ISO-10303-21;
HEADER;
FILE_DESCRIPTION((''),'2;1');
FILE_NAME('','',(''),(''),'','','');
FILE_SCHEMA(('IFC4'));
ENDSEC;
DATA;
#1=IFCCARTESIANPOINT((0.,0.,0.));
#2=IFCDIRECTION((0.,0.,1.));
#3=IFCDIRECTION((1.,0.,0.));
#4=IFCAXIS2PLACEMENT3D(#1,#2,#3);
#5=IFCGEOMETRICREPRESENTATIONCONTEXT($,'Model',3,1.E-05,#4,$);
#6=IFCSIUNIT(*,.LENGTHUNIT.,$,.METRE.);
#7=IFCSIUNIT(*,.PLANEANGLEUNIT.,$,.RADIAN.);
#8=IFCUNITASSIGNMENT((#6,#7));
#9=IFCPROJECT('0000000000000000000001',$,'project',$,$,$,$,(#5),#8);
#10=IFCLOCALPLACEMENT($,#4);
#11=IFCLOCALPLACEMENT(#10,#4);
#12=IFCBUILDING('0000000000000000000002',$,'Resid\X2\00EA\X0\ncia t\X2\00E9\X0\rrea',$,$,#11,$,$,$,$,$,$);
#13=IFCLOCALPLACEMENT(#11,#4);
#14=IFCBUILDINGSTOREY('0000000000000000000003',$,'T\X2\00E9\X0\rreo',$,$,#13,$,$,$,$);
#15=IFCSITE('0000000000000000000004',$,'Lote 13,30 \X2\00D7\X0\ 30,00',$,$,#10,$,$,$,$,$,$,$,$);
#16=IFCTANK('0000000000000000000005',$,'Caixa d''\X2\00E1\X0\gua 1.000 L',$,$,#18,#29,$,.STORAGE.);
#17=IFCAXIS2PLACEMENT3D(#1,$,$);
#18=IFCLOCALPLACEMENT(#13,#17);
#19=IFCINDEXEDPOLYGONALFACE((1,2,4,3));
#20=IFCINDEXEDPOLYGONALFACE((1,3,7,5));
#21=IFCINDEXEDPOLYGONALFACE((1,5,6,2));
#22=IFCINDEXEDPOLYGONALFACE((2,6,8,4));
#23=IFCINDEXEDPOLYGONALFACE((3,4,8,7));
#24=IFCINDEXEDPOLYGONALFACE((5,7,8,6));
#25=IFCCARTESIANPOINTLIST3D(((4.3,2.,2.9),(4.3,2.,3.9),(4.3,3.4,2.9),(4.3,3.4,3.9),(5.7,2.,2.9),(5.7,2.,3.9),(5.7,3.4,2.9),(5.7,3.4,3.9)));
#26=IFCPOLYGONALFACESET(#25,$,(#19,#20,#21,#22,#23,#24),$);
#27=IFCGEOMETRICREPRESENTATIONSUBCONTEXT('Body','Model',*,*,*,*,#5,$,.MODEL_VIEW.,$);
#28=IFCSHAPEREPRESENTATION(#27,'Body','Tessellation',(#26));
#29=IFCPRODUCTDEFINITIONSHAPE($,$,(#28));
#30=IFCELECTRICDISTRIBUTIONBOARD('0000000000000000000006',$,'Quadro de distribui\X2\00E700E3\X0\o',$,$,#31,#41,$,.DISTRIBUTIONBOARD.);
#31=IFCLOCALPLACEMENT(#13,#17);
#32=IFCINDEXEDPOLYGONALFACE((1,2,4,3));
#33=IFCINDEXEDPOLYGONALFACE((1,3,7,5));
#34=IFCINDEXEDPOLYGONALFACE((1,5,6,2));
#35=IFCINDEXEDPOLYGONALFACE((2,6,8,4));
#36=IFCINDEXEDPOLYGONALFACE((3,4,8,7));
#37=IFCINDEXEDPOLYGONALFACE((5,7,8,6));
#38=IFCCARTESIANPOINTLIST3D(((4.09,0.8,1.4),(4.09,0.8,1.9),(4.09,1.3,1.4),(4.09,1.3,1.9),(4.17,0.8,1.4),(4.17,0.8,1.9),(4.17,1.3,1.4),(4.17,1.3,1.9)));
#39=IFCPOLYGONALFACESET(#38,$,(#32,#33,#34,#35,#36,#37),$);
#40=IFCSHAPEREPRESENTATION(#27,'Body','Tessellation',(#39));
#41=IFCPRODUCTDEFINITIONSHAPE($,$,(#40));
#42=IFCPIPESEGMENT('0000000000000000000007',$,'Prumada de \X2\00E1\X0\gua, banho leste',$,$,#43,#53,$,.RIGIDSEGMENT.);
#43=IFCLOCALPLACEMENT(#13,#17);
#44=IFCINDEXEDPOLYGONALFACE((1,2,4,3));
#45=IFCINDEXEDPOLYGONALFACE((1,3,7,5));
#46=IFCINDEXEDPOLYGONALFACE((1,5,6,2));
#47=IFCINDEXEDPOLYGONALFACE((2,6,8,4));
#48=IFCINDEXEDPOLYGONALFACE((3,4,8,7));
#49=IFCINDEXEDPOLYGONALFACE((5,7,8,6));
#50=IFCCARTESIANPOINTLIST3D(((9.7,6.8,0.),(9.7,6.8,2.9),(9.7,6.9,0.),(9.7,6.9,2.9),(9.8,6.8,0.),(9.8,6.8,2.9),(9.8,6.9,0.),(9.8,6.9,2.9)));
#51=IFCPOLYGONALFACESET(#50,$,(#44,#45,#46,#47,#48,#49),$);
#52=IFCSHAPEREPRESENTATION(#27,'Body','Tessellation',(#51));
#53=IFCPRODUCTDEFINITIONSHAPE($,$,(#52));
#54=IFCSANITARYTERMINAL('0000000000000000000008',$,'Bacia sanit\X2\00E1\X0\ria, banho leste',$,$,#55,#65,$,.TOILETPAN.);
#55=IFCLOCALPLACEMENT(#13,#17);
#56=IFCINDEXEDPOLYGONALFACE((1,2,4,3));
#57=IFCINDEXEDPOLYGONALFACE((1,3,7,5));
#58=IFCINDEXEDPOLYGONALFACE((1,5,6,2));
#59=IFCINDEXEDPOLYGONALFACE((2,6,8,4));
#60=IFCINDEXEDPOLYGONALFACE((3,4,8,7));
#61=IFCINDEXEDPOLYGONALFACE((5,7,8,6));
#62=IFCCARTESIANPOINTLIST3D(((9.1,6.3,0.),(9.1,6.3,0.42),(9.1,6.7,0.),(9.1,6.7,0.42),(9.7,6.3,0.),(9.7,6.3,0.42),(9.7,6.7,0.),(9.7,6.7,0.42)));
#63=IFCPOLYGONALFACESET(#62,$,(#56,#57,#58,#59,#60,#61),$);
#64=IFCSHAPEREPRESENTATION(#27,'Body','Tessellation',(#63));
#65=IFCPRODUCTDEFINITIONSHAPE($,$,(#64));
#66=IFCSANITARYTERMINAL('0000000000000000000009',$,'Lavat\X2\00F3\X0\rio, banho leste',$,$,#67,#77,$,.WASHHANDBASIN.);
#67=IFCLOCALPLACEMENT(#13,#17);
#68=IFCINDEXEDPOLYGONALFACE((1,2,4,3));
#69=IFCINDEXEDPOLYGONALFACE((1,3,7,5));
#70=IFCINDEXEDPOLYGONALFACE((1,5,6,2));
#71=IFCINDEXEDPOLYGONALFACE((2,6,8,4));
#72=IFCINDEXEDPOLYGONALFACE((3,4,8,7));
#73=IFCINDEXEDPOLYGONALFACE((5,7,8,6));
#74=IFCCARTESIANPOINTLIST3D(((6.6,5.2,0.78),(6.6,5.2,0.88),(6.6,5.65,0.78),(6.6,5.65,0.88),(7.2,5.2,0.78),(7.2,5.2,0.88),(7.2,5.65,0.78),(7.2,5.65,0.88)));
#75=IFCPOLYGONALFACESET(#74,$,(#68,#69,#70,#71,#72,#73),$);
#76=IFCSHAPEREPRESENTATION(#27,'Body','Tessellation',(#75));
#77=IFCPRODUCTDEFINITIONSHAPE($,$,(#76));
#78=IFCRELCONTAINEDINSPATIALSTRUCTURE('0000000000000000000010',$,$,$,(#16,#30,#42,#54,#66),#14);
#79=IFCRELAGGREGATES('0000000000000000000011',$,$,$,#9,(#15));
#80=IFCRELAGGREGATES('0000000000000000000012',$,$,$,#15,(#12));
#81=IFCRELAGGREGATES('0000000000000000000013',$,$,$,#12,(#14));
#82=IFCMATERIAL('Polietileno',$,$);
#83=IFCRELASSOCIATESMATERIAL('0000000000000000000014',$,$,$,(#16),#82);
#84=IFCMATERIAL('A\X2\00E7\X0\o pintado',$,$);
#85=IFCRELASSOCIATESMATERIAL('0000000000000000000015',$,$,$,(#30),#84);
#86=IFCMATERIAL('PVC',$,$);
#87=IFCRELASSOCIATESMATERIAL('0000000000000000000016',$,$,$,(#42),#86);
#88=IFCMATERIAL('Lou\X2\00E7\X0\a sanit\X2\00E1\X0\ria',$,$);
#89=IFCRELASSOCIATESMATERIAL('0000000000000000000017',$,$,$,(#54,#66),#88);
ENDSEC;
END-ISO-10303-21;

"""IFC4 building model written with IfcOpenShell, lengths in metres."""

from ifc_helpers import new_model, si_unit, frame, origin_with_axes, place, context, subcontext, project, spatial, line, indexed_curve, outline, extrude, material, element, save


model = new_model("IFC4")

# Units and contexts
model_context = context("Model", 3, precision=1e-05, world=origin_with_axes())
body_context = subcontext(model_context, "Body", "Model", "MODEL_VIEW")
ifc_project = project(units=[si_unit("LENGTHUNIT", "METRE"), si_unit("PLANEANGLEUNIT", "RADIAN")], contexts=[model_context])

# Site, building, storey
site_placement = place(None, origin_with_axes())
site = spatial("IfcSite", under=ifc_project, at=site_placement, Name="Lote 13,30 × 30,00")
building_placement = place(site_placement, origin_with_axes())
building = spatial("IfcBuilding", under=site, at=building_placement, Name="Residência térrea")
storey_placement = place(building_placement, origin_with_axes())
storey = spatial("IfcBuildingStorey", under=building, at=storey_placement, Name="Térreo")

# Tank
ifc_material_1 = material(Name="Polietileno")
tank_placement = place(storey_placement, frame((4.3, 2.0, 2.9), z_axis=(0.0, 0.0, 1.0), x_axis=(1.0, 0.0, 0.0)))
element("IfcTank", 1, at=tank_placement, inside=storey, material=ifc_material_1, Name="Caixa d'água 1.000 L", PredefinedType="STORAGE", context=body_context, shape_type="SweptSolid", body=[
    extrude(outline(indexed_curve([(0.0, 0.0), (1.4, 0.0), (1.4, 1.4), (0.0, 1.4)], segments=[line(1, 2, 3, 4, 1)])), origin_with_axes(), (0.0, 0.0, 1.0), 1.0),
])

# Electric distribution board
ifc_material_2 = material(Name="Aço pintado")
electric_distribution_board_placement = place(storey_placement, frame((4.09, 0.8, 1.4), z_axis=(0.0, 0.0, 1.0), x_axis=(1.0, 0.0, 0.0)))
element("IfcElectricDistributionBoard", 2, at=electric_distribution_board_placement, inside=storey, material=ifc_material_2, Name="Quadro de distribuição", PredefinedType="DISTRIBUTIONBOARD", context=body_context, shape_type="SweptSolid", body=[
    extrude(outline(indexed_curve([(0.0, 0.0), (0.08, 0.0), (0.08, 0.5), (0.0, 0.5)], segments=[line(1, 2, 3, 4, 1)])), origin_with_axes(), (0.0, 0.0, 1.0), 0.5),
])

# Pipe segment
ifc_material_3 = material(Name="PVC")
pipe_segment_placement = place(storey_placement, frame((9.7, 6.8, 0.0), z_axis=(0.0, 0.0, 1.0), x_axis=(1.0, 0.0, 0.0)))
element("IfcPipeSegment", 3, at=pipe_segment_placement, inside=storey, material=ifc_material_3, Name="Prumada de água, banho leste", PredefinedType="RIGIDSEGMENT", context=body_context, shape_type="SweptSolid", body=[
    extrude(outline(indexed_curve([(0.0, 0.0), (0.1, 0.0), (0.1, 0.1), (0.0, 0.1)], segments=[line(1, 2, 3, 4, 1)])), origin_with_axes(), (0.0, 0.0, 1.0), 2.9),
])

# Sanitary terminals
ifc_material_4 = material(Name="Louça sanitária")
sanitary_terminal_1_placement = place(storey_placement, frame((9.1, 6.3, 0.0), z_axis=(0.0, 0.0, 1.0), x_axis=(1.0, 0.0, 0.0)))
element("IfcSanitaryTerminal", 4, at=sanitary_terminal_1_placement, inside=storey, material=ifc_material_4, Name="Bacia sanitária, banho leste", PredefinedType="TOILETPAN", context=body_context, shape_type="SweptSolid", body=[
    extrude(outline(indexed_curve([(0.0, 0.0), (0.6, 0.0), (0.6, 0.4), (0.0, 0.4)], segments=[line(1, 2, 3, 4, 1)])), origin_with_axes(), (0.0, 0.0, 1.0), 0.42),
])
sanitary_terminal_2_placement = place(storey_placement, frame((6.6, 5.2, 0.78), z_axis=(0.0, 0.0, 1.0), x_axis=(1.0, 0.0, 0.0)))
element("IfcSanitaryTerminal", 5, at=sanitary_terminal_2_placement, inside=storey, material=ifc_material_4, Name="Lavatório, banho leste", PredefinedType="WASHHANDBASIN", context=body_context, shape_type="SweptSolid", body=[
    extrude(outline(indexed_curve([(0.0, 0.0), (0.6, 0.0), (0.6, 0.45), (0.0, 0.45)], segments=[line(1, 2, 3, 4, 1)])), origin_with_axes(), (0.0, 0.0, 1.0), 0.1),
])

save(model, "model.ifc")
